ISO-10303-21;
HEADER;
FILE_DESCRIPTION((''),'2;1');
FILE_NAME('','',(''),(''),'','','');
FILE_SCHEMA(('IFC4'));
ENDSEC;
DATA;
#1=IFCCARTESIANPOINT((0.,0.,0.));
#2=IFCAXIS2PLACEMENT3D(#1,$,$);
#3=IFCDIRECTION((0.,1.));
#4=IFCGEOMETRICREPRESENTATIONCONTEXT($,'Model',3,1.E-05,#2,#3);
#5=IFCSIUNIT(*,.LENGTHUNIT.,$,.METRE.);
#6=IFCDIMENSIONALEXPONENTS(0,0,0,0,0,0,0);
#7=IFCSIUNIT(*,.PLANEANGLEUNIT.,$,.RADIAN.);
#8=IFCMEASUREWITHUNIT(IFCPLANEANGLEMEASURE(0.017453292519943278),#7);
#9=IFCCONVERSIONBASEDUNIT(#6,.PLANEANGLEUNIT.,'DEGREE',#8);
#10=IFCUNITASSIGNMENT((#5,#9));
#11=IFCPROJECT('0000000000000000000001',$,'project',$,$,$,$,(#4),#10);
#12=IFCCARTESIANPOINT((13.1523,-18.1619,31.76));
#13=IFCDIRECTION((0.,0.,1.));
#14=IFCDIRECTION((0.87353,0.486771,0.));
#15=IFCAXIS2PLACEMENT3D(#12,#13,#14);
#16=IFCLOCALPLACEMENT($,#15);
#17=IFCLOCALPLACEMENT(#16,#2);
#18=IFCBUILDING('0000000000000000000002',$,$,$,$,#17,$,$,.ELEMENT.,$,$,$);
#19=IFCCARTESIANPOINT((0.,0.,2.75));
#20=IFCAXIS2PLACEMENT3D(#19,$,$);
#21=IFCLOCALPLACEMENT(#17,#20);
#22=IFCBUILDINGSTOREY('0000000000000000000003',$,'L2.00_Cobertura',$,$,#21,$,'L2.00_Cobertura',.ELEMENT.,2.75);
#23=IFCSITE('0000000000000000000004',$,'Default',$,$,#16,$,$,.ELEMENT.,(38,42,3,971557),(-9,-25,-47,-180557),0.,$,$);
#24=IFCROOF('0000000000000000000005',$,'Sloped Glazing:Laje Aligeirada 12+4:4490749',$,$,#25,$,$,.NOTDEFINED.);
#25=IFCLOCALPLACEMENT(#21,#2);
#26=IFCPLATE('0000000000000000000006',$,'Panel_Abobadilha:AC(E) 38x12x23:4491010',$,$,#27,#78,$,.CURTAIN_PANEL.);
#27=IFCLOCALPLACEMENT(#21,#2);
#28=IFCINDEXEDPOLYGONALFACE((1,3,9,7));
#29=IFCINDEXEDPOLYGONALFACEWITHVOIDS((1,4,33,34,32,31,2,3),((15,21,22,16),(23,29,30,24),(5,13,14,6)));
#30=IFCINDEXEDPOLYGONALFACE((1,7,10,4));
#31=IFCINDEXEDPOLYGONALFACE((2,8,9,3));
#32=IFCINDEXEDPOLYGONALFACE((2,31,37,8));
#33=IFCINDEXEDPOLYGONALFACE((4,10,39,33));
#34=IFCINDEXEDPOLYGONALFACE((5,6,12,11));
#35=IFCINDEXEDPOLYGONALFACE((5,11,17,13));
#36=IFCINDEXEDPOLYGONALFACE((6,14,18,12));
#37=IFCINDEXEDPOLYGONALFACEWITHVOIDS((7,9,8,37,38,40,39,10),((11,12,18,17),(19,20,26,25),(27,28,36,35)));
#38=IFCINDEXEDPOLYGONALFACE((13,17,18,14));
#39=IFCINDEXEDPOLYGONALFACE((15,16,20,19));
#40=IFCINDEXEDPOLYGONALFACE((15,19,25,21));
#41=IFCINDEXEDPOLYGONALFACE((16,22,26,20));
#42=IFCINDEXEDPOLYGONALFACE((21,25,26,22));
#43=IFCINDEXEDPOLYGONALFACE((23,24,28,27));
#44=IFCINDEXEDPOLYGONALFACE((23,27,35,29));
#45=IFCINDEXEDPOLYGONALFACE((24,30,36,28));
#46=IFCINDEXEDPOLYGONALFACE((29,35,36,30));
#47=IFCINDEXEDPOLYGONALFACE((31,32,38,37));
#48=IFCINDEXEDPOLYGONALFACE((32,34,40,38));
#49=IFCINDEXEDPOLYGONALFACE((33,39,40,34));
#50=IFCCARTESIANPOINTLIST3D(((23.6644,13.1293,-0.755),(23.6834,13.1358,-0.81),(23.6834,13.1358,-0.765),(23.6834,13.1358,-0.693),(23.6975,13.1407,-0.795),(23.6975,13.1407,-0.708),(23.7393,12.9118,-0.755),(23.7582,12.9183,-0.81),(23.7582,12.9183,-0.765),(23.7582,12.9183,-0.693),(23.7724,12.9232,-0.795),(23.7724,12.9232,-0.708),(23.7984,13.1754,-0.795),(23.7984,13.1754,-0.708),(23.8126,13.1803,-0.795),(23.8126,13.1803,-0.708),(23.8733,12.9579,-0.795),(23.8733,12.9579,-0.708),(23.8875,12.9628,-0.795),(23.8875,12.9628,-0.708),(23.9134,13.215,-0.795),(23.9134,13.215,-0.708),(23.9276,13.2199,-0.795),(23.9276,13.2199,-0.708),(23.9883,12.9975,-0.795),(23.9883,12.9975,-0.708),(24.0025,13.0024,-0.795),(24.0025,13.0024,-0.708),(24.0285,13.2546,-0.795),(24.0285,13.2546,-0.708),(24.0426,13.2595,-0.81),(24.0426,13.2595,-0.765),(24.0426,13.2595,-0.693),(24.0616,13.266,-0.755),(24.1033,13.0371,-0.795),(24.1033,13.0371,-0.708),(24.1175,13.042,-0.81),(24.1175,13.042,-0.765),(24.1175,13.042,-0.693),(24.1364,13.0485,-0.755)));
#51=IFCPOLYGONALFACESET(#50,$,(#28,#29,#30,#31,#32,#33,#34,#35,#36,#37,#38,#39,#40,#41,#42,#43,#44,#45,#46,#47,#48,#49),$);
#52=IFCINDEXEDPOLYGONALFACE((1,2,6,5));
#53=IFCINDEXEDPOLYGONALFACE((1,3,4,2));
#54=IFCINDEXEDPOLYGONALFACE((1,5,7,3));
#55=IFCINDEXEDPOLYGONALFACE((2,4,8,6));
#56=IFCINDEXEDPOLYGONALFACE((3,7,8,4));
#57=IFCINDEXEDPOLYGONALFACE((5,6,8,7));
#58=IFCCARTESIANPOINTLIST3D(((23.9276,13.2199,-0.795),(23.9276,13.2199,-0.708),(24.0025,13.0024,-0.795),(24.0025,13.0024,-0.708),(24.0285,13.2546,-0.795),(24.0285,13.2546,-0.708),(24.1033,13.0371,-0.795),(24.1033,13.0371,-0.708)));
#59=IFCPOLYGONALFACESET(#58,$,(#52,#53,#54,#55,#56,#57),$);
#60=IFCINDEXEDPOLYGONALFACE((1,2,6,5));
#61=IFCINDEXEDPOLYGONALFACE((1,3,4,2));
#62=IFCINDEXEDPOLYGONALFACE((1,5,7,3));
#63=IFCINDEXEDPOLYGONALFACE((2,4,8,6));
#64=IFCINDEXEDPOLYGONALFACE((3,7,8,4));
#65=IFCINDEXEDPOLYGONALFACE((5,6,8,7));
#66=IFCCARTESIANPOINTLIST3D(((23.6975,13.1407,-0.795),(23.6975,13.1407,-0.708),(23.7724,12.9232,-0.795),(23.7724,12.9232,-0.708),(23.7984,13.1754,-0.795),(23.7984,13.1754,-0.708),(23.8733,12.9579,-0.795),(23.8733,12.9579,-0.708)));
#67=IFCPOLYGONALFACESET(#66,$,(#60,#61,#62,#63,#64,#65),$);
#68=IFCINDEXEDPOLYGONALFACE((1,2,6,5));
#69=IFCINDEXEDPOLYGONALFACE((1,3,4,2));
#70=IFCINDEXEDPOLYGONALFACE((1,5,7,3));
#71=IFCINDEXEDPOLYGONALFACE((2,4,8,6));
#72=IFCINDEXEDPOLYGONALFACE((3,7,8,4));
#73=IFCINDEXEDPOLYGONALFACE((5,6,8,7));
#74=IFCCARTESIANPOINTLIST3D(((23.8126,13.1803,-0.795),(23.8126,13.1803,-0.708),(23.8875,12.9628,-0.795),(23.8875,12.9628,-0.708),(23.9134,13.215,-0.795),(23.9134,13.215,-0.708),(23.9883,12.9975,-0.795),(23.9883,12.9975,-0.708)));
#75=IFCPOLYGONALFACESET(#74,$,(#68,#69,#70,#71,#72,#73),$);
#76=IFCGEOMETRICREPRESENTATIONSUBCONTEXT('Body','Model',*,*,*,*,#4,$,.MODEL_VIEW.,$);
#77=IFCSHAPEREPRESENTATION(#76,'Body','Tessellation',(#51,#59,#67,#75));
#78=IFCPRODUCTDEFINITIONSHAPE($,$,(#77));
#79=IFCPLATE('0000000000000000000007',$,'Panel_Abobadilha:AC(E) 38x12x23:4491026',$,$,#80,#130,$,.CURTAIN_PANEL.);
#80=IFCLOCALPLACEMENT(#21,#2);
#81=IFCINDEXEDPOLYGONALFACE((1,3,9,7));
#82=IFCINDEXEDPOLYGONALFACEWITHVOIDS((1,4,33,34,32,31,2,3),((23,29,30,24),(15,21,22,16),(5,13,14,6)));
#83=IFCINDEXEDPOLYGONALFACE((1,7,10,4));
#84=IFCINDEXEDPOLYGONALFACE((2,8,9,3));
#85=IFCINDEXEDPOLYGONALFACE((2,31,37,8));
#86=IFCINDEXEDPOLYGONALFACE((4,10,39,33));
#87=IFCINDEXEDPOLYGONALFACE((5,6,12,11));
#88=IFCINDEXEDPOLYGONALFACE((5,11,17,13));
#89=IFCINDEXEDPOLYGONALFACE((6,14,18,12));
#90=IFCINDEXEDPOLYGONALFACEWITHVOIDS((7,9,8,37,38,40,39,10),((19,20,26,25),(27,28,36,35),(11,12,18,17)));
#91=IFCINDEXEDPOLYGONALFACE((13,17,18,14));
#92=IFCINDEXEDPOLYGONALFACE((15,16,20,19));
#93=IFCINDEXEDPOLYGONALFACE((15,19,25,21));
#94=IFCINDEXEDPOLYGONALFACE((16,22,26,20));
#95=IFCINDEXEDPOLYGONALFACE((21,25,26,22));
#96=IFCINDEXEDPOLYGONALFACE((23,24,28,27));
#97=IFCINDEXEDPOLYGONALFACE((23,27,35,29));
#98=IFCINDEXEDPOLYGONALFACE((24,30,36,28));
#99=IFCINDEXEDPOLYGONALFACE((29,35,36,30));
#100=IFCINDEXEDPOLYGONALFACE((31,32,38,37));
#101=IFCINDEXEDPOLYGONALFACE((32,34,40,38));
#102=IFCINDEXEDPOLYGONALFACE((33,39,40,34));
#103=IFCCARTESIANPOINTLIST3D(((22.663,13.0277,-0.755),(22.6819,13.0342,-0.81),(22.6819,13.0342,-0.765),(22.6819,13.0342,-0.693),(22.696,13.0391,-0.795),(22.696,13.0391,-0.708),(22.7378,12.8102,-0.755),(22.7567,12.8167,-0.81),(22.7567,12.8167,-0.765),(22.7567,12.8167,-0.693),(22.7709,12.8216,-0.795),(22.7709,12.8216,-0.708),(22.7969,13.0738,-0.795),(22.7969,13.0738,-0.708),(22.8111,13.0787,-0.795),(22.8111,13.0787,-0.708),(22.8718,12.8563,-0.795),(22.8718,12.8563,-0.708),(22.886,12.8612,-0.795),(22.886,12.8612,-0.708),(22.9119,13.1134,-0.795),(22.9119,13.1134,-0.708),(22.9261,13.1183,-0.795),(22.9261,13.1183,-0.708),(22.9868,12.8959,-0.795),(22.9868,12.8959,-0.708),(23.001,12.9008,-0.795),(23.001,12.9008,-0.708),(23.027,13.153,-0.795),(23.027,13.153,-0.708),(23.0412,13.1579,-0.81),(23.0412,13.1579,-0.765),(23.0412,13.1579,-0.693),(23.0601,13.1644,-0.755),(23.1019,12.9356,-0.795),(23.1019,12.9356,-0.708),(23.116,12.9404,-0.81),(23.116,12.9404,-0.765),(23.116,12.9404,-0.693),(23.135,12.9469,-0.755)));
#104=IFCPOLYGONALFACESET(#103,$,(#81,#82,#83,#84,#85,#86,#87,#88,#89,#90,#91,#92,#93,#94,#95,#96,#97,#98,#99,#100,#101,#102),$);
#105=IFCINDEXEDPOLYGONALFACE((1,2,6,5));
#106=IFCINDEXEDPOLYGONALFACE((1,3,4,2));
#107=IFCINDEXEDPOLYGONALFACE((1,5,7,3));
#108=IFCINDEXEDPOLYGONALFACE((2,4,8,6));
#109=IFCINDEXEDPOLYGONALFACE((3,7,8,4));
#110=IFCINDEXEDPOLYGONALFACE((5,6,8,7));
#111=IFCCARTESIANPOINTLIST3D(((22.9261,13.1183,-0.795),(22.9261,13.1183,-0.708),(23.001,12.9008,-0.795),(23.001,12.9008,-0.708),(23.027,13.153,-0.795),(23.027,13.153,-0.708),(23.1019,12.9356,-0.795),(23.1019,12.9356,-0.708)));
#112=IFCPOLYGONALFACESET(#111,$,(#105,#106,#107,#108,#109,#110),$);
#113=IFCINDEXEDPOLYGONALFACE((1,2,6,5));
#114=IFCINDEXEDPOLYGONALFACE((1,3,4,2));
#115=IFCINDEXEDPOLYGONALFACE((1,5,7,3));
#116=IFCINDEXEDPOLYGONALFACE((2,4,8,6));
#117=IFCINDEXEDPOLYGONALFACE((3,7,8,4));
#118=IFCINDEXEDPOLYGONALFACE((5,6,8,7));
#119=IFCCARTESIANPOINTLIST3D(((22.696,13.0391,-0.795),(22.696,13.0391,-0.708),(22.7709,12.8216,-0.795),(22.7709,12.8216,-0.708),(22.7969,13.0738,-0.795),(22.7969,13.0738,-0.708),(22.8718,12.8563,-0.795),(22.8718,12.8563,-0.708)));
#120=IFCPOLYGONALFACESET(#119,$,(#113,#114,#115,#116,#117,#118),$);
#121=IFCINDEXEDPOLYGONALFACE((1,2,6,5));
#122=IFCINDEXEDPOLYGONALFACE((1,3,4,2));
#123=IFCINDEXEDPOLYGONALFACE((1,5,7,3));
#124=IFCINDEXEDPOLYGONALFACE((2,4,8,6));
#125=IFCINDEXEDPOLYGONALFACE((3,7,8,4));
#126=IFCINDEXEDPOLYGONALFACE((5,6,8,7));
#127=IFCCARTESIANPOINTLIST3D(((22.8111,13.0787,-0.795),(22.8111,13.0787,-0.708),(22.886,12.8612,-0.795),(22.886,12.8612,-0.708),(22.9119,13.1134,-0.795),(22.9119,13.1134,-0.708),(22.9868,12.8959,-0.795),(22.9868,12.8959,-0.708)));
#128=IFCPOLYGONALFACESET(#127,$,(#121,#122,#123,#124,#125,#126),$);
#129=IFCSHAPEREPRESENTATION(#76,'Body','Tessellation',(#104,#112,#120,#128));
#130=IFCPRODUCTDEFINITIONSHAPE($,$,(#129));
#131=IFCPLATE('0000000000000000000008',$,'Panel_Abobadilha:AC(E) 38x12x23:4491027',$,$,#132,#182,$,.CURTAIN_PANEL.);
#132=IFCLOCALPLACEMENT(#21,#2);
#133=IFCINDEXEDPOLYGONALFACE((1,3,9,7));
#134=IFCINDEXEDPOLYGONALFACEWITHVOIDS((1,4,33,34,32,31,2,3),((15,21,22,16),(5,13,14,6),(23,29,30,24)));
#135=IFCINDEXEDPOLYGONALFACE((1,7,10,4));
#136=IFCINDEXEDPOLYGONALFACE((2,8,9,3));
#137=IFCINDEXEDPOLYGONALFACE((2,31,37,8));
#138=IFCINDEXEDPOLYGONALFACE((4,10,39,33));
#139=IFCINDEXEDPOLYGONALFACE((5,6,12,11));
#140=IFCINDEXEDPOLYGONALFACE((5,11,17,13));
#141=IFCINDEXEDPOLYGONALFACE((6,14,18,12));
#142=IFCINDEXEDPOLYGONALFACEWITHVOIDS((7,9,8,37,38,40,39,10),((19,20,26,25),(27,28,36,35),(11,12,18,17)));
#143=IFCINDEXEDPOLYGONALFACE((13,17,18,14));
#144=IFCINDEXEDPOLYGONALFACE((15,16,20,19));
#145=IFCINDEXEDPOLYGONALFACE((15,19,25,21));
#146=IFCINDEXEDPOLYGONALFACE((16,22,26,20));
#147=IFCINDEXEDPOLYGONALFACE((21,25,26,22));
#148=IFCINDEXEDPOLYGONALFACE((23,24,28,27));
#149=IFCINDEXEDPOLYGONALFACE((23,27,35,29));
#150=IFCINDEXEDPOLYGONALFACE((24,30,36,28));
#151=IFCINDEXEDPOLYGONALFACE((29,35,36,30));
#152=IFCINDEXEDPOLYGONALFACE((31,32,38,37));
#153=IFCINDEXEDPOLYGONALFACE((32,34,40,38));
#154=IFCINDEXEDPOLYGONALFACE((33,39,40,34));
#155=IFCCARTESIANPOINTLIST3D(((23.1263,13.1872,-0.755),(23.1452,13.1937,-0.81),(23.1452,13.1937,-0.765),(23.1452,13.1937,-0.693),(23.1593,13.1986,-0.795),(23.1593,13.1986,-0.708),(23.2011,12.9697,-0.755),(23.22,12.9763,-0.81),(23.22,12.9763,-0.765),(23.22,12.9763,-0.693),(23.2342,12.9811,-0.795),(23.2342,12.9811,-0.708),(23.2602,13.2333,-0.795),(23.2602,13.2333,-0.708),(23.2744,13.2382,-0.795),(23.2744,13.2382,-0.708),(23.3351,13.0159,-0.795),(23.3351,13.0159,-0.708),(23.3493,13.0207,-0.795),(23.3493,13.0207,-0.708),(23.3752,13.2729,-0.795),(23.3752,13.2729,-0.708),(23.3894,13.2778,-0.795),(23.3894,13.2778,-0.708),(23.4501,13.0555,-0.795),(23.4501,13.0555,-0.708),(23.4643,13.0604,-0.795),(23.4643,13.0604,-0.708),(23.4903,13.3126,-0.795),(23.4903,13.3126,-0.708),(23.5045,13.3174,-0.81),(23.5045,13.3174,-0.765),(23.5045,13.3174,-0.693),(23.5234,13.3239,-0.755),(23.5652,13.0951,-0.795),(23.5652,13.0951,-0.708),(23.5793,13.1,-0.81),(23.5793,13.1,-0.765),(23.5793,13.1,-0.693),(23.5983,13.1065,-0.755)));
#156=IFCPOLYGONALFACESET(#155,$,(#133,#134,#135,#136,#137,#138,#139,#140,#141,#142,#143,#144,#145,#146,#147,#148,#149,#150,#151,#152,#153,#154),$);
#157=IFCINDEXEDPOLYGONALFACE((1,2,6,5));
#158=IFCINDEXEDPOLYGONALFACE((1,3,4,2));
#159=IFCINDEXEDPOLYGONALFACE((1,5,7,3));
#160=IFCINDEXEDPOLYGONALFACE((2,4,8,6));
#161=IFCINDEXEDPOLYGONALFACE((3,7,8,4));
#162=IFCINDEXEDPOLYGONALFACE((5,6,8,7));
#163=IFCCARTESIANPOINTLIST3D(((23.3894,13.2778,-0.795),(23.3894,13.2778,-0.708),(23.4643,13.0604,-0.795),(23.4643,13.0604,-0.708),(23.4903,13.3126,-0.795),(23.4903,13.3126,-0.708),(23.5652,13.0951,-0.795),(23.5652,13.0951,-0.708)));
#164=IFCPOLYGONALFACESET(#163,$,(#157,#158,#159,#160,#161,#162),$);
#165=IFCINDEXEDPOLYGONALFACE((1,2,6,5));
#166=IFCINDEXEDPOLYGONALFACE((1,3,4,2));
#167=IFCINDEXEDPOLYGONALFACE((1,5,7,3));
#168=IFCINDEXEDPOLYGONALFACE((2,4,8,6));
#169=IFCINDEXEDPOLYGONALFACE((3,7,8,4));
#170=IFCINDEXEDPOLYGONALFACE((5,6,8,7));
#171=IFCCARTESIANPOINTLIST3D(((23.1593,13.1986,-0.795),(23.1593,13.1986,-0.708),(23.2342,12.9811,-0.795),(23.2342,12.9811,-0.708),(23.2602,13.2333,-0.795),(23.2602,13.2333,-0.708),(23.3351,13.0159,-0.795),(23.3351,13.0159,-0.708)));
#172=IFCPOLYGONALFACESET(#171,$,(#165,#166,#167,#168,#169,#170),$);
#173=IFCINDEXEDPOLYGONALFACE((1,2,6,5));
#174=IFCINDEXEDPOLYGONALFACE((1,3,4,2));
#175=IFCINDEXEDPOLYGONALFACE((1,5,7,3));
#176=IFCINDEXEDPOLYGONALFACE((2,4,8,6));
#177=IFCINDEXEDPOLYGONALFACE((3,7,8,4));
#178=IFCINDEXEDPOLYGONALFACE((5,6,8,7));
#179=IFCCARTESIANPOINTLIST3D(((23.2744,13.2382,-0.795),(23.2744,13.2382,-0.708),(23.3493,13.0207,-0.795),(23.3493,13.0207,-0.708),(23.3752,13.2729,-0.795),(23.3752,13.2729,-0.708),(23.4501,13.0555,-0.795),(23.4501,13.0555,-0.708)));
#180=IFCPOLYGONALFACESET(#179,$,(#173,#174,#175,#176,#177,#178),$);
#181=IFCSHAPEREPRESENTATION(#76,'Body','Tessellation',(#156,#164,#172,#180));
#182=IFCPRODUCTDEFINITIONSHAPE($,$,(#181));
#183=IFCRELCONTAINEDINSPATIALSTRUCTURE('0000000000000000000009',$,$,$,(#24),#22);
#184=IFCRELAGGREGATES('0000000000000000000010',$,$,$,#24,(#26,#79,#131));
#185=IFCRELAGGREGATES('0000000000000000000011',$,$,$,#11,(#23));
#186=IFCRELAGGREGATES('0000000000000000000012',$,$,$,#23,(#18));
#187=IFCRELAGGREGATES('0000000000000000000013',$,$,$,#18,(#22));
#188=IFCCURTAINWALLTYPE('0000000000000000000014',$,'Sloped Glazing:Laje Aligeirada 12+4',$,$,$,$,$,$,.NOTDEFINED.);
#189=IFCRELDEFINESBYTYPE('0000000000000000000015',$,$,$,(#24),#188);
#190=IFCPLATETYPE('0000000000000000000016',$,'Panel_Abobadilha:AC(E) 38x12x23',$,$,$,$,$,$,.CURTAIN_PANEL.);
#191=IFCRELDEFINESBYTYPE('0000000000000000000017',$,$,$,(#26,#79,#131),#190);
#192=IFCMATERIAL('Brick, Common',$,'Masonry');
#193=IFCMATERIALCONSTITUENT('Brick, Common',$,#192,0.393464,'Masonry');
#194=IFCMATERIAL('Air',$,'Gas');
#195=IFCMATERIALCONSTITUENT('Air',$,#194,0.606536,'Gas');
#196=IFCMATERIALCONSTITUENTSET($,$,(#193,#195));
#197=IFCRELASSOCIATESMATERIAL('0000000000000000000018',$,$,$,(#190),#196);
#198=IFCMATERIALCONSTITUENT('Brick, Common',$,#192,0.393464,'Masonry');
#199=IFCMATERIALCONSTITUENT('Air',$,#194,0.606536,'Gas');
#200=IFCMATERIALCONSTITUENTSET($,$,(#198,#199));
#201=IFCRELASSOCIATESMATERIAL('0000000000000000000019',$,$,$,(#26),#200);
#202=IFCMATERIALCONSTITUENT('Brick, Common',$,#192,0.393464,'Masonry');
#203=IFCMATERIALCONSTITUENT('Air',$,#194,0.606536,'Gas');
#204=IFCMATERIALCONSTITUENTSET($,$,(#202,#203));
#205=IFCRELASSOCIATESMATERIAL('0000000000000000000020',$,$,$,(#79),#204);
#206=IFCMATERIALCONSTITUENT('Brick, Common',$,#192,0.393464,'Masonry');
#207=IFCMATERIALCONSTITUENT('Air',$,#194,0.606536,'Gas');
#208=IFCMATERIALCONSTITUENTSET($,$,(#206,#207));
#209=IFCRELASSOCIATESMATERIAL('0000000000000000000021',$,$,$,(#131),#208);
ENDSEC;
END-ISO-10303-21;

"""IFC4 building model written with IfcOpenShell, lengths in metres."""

from ifc_helpers import new_model, entity, si_unit, converted_unit, direction, frame, origin, place, context, subcontext, project, spatial, indexed_curve, outline, extrude, source, transform, mapped, material, constituent, constituent_set, type_object, type_shapes, element, aggregate, save


model = new_model("IFC4")

# Units and contexts
model_context = context("Model", 3, precision=1e-05, world=origin(), true_north=direction((0.0, 1.0)))
body_context = subcontext(model_context, "Body", "Model", "MODEL_VIEW")
ifc_project = project(units=[si_unit("LENGTHUNIT", "METRE"), converted_unit("PLANEANGLEUNIT", "DEGREE", entity("IfcPlaneAngleMeasure", 0.017453292519943278), si_unit("PLANEANGLEUNIT", "RADIAN"), dimensions=[0, 0, 0, 0, 0, 0, 0])], contexts=[model_context])

# Site, building, storey
site_placement = place(None, frame((13.1523, -18.1619, 31.76), z_axis=(0.0, 0.0, 1.0), x_axis=(0.87353, 0.486771, 0.0)))
site = spatial("IfcSite", under=ifc_project, at=site_placement, Name="Default", CompositionType="ELEMENT", RefLatitude=(38, 42, 3, 971557), RefLongitude=(-9, -25, -47, -180557), RefElevation=0.0)
building_placement = place(site_placement, origin())
building = spatial("IfcBuilding", under=site, at=building_placement, CompositionType="ELEMENT")
storey_placement = place(building_placement, frame((0.0, 0.0, 2.75)))
storey = spatial("IfcBuildingStorey", under=building, at=storey_placement, Name="L2.00_Cobertura", LongName="L2.00_Cobertura", CompositionType="ELEMENT", Elevation=2.75)

# Roof, plates
curtain_wall_type = type_object("IfcCurtainWallType", Name="Sloped Glazing:Laje Aligeirada 12+4", PredefinedType="NOTDEFINED")
roof_placement = place(storey_placement, frame((0.0, 0.0, -2.75)))
roof = element("IfcRoof", 1, at=roof_placement, inside=storey, type_object=curtain_wall_type, Name="Sloped Glazing:Laje Aligeirada 12+4:4490749", PredefinedType="NOTDEFINED")
ifc_material_1 = material(Name="Brick, Common", Category="Masonry")
ifc_material_2 = material(Name="Air", Category="Gas")
ifc_constituent_1 = constituent(ifc_material_1, Name="Brick, Common", Category="Masonry", fraction=0.393464)
ifc_constituent_2 = constituent(ifc_material_2, Name="Air", Category="Gas", fraction=0.606536)
ifc_constituent_set_1 = constituent_set(constituents=[ifc_constituent_1, ifc_constituent_2])
plate_type = type_object("IfcPlateType", Name="Panel_Abobadilha:AC(E) 38x12x23", PredefinedType="CURTAIN_PANEL", material=ifc_constituent_set_1)
shared_shape_1 = source(origin(), body_context, "Body", "SweptSolid", [
    extrude(outline(indexed_curve([(-0.19, -0.0543), (0.19, -0.0543), (0.19, -0.0093), (0.21, 0.0007), (0.19, 0.0628), (-0.19, 0.0628), (-0.21, 0.0007), (-0.19, -0.0093), (-0.19, -0.0543)], self_intersect=False), holes=[indexed_curve([(-0.0683, 0.0477), (-0.0683, -0.0393), (-0.175, -0.0393), (-0.175, 0.0477), (-0.0683, 0.0477)], self_intersect=False), indexed_curve([(0.0533, 0.0477), (0.0533, -0.0393), (-0.0533, -0.0393), (-0.0533, 0.0477), (0.0533, 0.0477)], self_intersect=False), indexed_curve([(0.175, 0.0477), (0.175, -0.0393), (0.0683, -0.0393), (0.0683, 0.0477), (0.175, 0.0477)], self_intersect=False)]), frame((0.0, 0.0543, 0.0)), (0.0, 0.0, 1.0), 0.23),
    extrude(outline(indexed_curve([(-0.0533, -0.0435), (0.0533, -0.0435), (0.0533, 0.0435), (-0.0533, 0.0435), (-0.0533, -0.0435)], self_intersect=False)), frame((0.1217, 0.0585, 0.0), z_axis=(0.0, 0.0, 1.0), x_axis=(-1.0, 0.0, 0.0)), (0.0, 0.0, 1.0), 0.23),
    extrude(outline(indexed_curve([(-0.0533, -0.0435), (0.0533, -0.0435), (0.0533, 0.0435), (-0.0533, 0.0435), (-0.0533, -0.0435)], self_intersect=False)), frame((-0.1217, 0.0585, 0.0), z_axis=(0.0, 0.0, 1.0), x_axis=(-1.0, 0.0, 0.0)), (0.0, 0.0, 1.0), 0.23),
    extrude(outline(indexed_curve([(-0.0533, -0.0435), (0.0533, -0.0435), (0.0533, 0.0435), (-0.0533, 0.0435), (-0.0533, -0.0435)], self_intersect=False)), frame((0.0, 0.0585, 0.0), z_axis=(0.0, 0.0, 1.0), x_axis=(-1.0, 0.0, 0.0)), (0.0, 0.0, 1.0), 0.23),
])
type_shapes(plate_type, [shared_shape_1])
ifc_constituent_3 = constituent(ifc_material_1, Name="Brick, Common", Category="Masonry", fraction=0.393464)
ifc_constituent_4 = constituent(ifc_material_2, Name="Air", Category="Gas", fraction=0.606536)
ifc_constituent_set_2 = constituent_set(constituents=[ifc_constituent_3, ifc_constituent_4])
plate_1_placement = place(roof_placement, frame((23.863, 13.1976, 1.94), z_axis=(0.325568, -0.945519, 0.0), x_axis=(0.945519, 0.325568, 0.0)))
plate_1 = element("IfcPlate", 2, at=plate_1_placement, type_object=plate_type, material=ifc_constituent_set_2, Name="Panel_Abobadilha:AC(E) 38x12x23:4491010", PredefinedType="CURTAIN_PANEL", context=body_context, shape_type="MappedRepresentation", body=[
    mapped(shared_shape_1, transform((0.0, 0.0, 0.0), scale=1.0)),
])
ifc_constituent_5 = constituent(ifc_material_1, Name="Brick, Common", Category="Masonry", fraction=0.393464)
ifc_constituent_6 = constituent(ifc_material_2, Name="Air", Category="Gas", fraction=0.606536)
ifc_constituent_set_3 = constituent_set(constituents=[ifc_constituent_5, ifc_constituent_6])
plate_2_placement = place(roof_placement, frame((22.8615, 13.096, 1.94), z_axis=(0.325568, -0.945519, 0.0), x_axis=(0.945519, 0.325568, 0.0)))
plate_2 = element("IfcPlate", 3, at=plate_2_placement, type_object=plate_type, material=ifc_constituent_set_3, Name="Panel_Abobadilha:AC(E) 38x12x23:4491026", PredefinedType="CURTAIN_PANEL", context=body_context, shape_type="MappedRepresentation", body=[
    mapped(shared_shape_1, transform((0.0, 0.0, 0.0), scale=1.0)),
])
ifc_constituent_7 = constituent(ifc_material_1, Name="Brick, Common", Category="Masonry", fraction=0.393464)
ifc_constituent_8 = constituent(ifc_material_2, Name="Air", Category="Gas", fraction=0.606536)
ifc_constituent_set_4 = constituent_set(constituents=[ifc_constituent_7, ifc_constituent_8])
plate_3_placement = place(roof_placement, frame((23.3248, 13.2556, 1.94), z_axis=(0.325568, -0.945519, 0.0), x_axis=(0.945519, 0.325568, 0.0)))
plate_3 = element("IfcPlate", 4, at=plate_3_placement, type_object=plate_type, material=ifc_constituent_set_4, Name="Panel_Abobadilha:AC(E) 38x12x23:4491027", PredefinedType="CURTAIN_PANEL", context=body_context, shape_type="MappedRepresentation", body=[
    mapped(shared_shape_1, transform((0.0, 0.0, 0.0), scale=1.0)),
])
aggregate(roof, [plate_1, plate_2, plate_3])

save(model, "model.ifc")
